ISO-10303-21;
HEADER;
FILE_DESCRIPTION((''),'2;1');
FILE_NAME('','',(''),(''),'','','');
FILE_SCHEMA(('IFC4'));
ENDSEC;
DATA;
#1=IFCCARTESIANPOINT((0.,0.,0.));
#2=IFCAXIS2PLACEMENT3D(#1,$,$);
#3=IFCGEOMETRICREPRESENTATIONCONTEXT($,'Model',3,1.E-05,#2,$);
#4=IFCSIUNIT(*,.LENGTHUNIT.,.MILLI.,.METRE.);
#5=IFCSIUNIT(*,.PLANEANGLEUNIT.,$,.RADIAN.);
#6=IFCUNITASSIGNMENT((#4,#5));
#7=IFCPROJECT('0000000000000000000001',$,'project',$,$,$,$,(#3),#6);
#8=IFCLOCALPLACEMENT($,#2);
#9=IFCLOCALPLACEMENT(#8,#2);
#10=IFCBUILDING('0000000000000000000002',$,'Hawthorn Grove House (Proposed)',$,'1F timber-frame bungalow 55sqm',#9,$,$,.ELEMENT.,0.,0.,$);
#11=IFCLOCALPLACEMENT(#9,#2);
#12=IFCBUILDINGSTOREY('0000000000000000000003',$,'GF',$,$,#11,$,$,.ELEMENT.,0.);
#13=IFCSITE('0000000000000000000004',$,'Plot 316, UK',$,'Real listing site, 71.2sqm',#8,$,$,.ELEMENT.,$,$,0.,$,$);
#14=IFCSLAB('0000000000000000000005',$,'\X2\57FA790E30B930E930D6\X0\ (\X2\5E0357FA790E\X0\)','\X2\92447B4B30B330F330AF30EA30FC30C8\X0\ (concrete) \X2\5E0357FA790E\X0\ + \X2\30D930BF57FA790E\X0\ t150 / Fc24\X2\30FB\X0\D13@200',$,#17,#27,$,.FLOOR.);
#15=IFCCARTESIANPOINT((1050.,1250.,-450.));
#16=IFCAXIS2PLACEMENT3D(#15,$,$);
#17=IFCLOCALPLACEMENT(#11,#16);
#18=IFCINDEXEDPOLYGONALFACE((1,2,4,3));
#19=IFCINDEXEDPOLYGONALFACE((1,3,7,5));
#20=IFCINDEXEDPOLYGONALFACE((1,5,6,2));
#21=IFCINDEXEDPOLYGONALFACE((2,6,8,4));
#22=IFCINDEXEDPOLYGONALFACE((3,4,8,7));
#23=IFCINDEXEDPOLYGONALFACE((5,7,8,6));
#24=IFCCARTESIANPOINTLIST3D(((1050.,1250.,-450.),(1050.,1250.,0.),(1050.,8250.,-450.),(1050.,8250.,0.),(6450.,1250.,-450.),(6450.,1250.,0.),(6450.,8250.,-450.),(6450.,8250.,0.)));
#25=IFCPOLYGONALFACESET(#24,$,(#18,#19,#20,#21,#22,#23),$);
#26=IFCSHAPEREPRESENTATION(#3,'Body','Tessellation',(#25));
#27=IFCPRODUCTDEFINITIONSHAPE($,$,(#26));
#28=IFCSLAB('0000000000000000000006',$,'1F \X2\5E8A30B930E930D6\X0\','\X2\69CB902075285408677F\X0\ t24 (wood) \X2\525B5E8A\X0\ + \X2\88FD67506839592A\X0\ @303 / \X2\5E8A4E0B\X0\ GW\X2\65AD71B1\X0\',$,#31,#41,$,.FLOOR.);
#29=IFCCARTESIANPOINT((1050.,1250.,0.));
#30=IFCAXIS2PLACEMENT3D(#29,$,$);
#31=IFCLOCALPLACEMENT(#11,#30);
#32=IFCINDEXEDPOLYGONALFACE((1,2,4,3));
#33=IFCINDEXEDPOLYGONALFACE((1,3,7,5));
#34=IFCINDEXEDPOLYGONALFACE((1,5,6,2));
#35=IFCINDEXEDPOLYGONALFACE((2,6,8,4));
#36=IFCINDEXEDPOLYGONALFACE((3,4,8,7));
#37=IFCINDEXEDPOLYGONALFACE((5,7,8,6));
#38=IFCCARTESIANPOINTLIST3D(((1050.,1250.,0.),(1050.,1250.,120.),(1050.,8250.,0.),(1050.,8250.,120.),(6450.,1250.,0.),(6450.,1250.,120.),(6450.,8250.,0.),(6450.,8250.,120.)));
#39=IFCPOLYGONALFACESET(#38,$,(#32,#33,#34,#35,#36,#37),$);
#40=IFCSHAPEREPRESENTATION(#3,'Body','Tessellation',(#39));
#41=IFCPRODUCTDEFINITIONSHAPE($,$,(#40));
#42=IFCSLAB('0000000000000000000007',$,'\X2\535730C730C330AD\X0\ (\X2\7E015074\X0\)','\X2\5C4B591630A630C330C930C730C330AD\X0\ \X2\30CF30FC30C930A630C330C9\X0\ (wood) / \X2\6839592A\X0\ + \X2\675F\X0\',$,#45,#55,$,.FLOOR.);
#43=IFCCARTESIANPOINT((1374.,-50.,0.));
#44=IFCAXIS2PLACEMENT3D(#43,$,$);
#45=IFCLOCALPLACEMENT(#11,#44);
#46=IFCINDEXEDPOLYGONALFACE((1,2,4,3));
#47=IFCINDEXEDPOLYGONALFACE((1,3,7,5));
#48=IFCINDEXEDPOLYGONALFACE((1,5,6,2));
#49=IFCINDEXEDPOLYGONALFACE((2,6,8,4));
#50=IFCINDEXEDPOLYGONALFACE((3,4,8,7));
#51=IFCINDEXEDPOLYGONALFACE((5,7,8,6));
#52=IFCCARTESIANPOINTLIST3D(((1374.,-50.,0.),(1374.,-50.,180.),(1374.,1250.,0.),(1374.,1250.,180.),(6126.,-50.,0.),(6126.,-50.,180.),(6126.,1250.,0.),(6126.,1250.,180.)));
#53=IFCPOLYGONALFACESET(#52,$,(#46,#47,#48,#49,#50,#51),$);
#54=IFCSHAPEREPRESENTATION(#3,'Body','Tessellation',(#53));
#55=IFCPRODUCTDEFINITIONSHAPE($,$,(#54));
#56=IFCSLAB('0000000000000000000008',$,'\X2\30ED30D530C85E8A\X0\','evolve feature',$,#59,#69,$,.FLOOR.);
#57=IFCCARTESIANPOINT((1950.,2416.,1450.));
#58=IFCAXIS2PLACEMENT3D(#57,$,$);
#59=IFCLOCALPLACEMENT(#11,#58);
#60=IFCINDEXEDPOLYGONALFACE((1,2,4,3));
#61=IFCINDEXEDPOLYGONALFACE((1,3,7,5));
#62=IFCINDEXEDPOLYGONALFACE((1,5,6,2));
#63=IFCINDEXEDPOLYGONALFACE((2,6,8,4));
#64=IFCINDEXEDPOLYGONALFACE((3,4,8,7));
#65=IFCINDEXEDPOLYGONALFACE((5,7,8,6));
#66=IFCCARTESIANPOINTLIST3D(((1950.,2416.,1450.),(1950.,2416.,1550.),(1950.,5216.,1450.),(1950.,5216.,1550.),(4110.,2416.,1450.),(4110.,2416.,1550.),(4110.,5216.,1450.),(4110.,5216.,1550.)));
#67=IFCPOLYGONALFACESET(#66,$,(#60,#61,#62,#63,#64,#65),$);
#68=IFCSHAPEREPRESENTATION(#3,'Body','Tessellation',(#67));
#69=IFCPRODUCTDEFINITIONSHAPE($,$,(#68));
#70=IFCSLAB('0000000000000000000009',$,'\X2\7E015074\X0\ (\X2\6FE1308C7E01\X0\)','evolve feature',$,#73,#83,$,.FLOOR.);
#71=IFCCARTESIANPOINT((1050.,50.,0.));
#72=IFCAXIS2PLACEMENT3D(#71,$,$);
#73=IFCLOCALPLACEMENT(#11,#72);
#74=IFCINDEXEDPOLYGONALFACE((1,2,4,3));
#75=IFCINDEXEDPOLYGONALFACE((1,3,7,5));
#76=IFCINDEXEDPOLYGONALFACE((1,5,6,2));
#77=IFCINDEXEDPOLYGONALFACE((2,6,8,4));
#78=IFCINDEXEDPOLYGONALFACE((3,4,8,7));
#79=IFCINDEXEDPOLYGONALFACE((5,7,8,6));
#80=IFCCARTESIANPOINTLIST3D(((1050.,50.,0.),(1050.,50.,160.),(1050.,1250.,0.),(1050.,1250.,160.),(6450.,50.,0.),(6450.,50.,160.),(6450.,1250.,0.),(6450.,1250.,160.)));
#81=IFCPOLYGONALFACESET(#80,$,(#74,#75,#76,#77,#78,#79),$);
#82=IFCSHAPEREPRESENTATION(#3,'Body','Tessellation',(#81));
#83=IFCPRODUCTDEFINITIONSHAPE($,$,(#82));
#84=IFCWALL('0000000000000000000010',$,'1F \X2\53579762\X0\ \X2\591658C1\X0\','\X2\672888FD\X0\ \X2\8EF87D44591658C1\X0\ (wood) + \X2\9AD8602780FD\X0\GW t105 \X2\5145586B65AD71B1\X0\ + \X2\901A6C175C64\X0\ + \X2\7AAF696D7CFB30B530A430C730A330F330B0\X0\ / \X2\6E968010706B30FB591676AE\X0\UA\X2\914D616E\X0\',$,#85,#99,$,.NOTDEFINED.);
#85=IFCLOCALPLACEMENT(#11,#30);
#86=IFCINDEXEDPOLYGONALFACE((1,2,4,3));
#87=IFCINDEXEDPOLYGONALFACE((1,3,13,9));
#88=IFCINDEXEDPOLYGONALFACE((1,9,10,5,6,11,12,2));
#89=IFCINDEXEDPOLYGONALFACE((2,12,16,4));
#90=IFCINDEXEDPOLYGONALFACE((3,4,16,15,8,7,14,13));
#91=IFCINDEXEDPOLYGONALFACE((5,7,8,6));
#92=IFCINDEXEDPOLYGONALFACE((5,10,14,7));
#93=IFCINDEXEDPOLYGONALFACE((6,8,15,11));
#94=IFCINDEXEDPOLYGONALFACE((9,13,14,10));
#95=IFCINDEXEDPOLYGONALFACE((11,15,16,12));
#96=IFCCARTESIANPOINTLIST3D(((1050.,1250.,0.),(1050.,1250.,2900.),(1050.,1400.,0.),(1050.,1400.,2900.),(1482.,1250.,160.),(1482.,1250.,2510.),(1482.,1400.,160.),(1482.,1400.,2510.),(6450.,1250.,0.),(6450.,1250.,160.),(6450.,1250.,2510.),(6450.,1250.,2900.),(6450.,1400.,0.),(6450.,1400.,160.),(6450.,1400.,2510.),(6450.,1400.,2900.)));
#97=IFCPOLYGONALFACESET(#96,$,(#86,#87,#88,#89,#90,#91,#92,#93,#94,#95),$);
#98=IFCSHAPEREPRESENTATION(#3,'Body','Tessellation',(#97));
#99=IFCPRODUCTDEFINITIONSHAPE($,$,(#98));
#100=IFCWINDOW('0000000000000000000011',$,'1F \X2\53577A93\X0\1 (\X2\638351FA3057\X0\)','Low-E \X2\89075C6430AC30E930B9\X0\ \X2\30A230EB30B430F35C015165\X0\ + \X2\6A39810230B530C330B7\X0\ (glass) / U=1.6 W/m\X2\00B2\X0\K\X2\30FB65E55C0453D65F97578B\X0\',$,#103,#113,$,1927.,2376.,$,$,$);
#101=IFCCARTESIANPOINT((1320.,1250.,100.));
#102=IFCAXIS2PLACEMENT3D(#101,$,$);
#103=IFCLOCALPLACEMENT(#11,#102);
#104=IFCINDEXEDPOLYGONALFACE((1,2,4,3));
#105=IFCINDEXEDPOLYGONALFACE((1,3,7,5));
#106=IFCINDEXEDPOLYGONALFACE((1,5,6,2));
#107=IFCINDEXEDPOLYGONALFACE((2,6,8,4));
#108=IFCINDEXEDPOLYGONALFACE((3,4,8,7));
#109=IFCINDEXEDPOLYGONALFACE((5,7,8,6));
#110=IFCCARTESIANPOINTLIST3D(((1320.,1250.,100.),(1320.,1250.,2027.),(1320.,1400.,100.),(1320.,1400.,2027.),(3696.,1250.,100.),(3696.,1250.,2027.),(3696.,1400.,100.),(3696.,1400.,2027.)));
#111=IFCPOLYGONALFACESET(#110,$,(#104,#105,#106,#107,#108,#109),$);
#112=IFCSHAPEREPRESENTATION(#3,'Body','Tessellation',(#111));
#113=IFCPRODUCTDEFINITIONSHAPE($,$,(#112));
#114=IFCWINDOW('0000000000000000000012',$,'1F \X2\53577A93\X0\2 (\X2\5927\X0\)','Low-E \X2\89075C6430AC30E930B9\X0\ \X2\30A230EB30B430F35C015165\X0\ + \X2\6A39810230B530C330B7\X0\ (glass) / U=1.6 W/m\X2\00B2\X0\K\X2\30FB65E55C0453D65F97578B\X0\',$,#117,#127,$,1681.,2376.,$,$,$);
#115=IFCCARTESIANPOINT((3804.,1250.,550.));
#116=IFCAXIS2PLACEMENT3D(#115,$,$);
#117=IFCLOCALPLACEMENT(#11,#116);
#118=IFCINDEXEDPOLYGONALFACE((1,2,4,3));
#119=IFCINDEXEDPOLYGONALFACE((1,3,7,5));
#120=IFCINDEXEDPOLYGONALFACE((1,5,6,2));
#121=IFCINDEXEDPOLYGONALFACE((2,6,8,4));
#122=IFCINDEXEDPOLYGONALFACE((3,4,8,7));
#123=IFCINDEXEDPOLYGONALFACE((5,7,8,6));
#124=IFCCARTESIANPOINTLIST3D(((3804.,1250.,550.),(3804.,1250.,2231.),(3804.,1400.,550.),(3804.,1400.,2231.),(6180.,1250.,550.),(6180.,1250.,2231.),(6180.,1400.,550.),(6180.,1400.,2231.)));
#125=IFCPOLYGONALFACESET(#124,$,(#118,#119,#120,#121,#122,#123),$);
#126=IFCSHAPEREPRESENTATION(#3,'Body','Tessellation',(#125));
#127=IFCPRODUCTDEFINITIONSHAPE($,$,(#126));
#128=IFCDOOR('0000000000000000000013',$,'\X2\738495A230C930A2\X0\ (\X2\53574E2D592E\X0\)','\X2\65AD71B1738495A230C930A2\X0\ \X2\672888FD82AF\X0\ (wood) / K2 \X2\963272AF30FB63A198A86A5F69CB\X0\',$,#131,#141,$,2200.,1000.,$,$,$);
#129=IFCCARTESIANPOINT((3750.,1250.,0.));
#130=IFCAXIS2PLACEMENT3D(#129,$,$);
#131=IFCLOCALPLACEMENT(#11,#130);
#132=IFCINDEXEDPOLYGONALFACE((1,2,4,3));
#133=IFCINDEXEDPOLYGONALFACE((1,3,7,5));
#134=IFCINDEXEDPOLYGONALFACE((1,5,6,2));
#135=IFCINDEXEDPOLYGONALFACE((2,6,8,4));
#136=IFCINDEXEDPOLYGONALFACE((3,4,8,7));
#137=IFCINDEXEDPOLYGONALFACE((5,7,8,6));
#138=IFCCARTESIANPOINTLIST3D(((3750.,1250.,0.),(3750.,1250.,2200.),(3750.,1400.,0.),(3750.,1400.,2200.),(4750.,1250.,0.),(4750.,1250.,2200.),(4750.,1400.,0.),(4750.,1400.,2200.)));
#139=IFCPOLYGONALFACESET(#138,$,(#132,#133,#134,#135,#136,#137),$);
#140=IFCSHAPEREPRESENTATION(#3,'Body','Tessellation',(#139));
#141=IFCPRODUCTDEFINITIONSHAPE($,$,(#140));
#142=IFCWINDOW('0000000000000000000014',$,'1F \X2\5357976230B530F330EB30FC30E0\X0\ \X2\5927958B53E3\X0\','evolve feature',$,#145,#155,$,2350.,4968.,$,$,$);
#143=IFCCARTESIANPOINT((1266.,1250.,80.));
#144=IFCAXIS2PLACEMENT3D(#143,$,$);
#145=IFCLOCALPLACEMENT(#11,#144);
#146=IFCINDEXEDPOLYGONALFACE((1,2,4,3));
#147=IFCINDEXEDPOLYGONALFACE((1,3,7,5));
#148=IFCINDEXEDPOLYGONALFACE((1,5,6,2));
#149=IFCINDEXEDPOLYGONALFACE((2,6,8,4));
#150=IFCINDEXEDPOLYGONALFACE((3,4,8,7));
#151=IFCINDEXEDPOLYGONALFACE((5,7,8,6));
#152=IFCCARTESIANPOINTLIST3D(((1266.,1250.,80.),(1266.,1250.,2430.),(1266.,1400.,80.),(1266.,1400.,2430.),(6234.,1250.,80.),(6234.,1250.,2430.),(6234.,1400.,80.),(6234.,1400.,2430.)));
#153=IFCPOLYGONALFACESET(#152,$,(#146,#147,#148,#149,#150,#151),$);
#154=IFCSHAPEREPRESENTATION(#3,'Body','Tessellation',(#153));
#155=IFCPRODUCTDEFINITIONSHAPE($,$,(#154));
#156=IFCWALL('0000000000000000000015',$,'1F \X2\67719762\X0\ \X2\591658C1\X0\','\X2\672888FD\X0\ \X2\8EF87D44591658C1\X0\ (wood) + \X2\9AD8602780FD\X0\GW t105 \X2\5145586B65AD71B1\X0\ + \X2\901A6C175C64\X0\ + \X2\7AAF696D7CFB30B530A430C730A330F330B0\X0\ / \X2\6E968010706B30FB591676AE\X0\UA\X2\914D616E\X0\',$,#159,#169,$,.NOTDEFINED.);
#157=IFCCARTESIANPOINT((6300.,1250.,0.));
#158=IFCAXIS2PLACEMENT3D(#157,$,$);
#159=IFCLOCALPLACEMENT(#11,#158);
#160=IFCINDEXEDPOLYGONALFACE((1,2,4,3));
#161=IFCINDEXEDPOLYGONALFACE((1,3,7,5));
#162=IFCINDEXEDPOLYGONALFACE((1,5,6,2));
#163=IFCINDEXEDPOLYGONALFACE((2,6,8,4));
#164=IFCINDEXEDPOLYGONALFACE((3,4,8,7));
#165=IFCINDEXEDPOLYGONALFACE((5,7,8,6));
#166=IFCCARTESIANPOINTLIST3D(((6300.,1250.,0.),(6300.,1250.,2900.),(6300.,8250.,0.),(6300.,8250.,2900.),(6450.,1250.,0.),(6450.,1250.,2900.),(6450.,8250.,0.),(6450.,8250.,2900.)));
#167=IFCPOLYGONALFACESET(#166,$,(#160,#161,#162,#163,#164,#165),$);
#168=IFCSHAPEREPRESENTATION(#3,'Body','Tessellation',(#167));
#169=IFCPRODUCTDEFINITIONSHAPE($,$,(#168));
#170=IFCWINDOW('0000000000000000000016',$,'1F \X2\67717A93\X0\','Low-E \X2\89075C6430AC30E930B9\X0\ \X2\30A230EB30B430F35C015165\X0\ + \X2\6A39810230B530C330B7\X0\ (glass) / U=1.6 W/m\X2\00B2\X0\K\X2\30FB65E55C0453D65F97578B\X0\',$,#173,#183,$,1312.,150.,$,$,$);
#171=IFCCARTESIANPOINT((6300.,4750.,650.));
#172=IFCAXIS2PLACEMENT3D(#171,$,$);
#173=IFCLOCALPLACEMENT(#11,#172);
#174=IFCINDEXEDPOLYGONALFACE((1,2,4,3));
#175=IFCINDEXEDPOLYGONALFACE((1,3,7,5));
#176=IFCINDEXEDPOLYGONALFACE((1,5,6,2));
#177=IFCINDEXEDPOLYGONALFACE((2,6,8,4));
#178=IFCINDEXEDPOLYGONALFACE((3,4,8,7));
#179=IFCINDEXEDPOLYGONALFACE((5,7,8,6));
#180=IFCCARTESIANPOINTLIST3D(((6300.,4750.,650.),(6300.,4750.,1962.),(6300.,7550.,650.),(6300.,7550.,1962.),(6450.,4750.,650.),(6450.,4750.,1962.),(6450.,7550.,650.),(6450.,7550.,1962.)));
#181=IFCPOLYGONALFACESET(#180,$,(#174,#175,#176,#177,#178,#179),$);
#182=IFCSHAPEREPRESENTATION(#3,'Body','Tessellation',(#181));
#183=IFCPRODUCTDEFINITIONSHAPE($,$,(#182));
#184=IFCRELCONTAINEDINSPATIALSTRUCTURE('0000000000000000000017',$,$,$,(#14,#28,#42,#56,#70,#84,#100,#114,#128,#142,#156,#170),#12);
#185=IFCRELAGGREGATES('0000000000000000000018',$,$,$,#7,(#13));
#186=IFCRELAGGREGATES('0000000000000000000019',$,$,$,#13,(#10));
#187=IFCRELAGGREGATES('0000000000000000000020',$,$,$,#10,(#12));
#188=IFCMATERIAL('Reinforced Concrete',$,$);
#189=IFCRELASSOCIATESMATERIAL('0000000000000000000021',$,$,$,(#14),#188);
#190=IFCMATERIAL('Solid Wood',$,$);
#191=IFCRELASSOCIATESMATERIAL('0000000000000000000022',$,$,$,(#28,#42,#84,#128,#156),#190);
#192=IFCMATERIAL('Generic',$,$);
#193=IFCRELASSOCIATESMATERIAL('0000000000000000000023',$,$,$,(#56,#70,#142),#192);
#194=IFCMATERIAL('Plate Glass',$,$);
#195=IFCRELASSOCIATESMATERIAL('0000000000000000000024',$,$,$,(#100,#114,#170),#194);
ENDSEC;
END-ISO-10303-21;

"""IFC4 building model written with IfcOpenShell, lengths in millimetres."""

from ifc_helpers import new_model, si_unit, frame, frame_2d, origin, place, context, project, spatial, rectangle, extrude, material, element, fill, save


model = new_model("IFC4")

# Units and contexts
model_context = context("Model", 3, precision=1e-05, world=origin())
ifc_project = project(units=[si_unit("LENGTHUNIT", "METRE", prefix="MILLI"), si_unit("PLANEANGLEUNIT", "RADIAN")], contexts=[model_context])

# Site, building, storey
site_placement = place(None, origin())
site = spatial("IfcSite", under=ifc_project, at=site_placement, Name="Plot 316, UK", ObjectType="Real listing site, 71.2sqm", CompositionType="ELEMENT", RefElevation=0.0)
building_placement = place(site_placement, origin())
building = spatial("IfcBuilding", under=site, at=building_placement, Name="Hawthorn Grove House (Proposed)", ObjectType="1F timber-frame bungalow 55sqm", CompositionType="ELEMENT", ElevationOfRefHeight=0.0, ElevationOfTerrain=0.0)
storey_placement = place(building_placement, origin())
storey = spatial("IfcBuildingStorey", under=building, at=storey_placement, Name="GF", CompositionType="ELEMENT", Elevation=0.0)

# Slabs
ifc_material_1 = material(Name="Reinforced Concrete")
slab_1_placement = place(storey_placement, frame((1050.0, 1250.0, -450.0)))
element("IfcSlab", 1, at=slab_1_placement, inside=storey, material=ifc_material_1, Name="基礎スラブ (布基礎)", Description="鉄筋コンクリート (concrete) 布基礎 + ベタ基礎 t150 / Fc24・D13@200", PredefinedType="FLOOR", context=model_context, shape_type="SweptSolid", body=[
    extrude(rectangle(XDim=5400.0, YDim=7000.0, at=frame_2d((2700.0, 3500.0))), frame((1050.0, 1250.0, -450.0)), (0.0, 0.0, 1.0), 450.0),
])
ifc_material_2 = material(Name="Solid Wood")
slab_2_placement = place(storey_placement, frame((1050.0, 1250.0, 0.0)))
element("IfcSlab", 2, at=slab_2_placement, inside=storey, material=ifc_material_2, Name="1F 床スラブ", Description="構造用合板 t24 (wood) 剛床 + 製材根太 @303 / 床下 GW断熱", PredefinedType="FLOOR", context=model_context, shape_type="SweptSolid", body=[
    extrude(rectangle(XDim=5400.0, YDim=7000.0, at=frame_2d((2700.0, 3500.0))), frame((1050.0, 1250.0, 0.0)), (0.0, 0.0, 1.0), 120.0),
])
slab_3_placement = place(storey_placement, frame((1374.0, -50.0, 0.0)))
element("IfcSlab", 3, at=slab_3_placement, inside=storey, material=ifc_material_2, Name="南デッキ (縁側)", Description="屋外ウッドデッキ ハードウッド (wood) / 根太 + 束", PredefinedType="FLOOR", context=model_context, shape_type="SweptSolid", body=[
    extrude(rectangle(XDim=4752.0, YDim=1300.0, at=frame_2d((2376.0, 650.0))), frame((1374.0, -50.0, 0.0)), (0.0, 0.0, 1.0), 180.0),
])
ifc_material_3 = material(Name="Generic")
slab_4_placement = place(storey_placement, frame((1950.0, 2416.0, 1450.0)))
element("IfcSlab", 4, at=slab_4_placement, inside=storey, material=ifc_material_3, Name="ロフト床", Description="evolve feature", PredefinedType="FLOOR", context=model_context, shape_type="SweptSolid", body=[
    extrude(rectangle(XDim=2160.0, YDim=2800.0, at=frame_2d((1080.0, 1400.0))), frame((1950.0, 2416.0, 1450.0)), (0.0, 0.0, 1.0), 100.0),
])
slab_5_placement = place(storey_placement, frame((1050.0, 50.0, 0.0)))
element("IfcSlab", 5, at=slab_5_placement, inside=storey, material=ifc_material_3, Name="縁側 (濡れ縁)", Description="evolve feature", PredefinedType="FLOOR", context=model_context, shape_type="SweptSolid", body=[
    extrude(rectangle(XDim=5400.0, YDim=1200.0, at=frame_2d((2700.0, 600.0))), frame((1050.0, 50.0, 0.0)), (0.0, 0.0, 1.0), 160.0),
])

# Wall, openings, windows, door
wall_1_placement = place(storey_placement, frame((1050.0, 1250.0, 0.0)))
wall_1 = element("IfcWall", 6, at=wall_1_placement, inside=storey, material=ifc_material_2, Name="1F 南面 外壁", Description="木製 軸組外壁 (wood) + 高性能GW t105 充填断熱 + 通気層 + 窯業系サイディング / 準耐火・外皮UA配慮", PredefinedType="NOTDEFINED", context=model_context, shape_type="SweptSolid", body=[
    extrude(rectangle(XDim=5400.0, YDim=150.0, at=frame_2d((2700.0, 75.0))), frame((1050.0, 1250.0, 0.0)), (0.0, 0.0, 1.0), 2900.0),
])
opening_1_placement = place(storey_placement, frame((1320.0, 1250.0, 100.0)))
opening_1 = element("IfcOpeningElement", 7, at=opening_1_placement, cuts=wall_1, PredefinedType="NOTDEFINED", context=model_context, shape_type="SweptSolid", body=[
    extrude(rectangle(XDim=2376.0, YDim=150.0, at=frame_2d((1188.0, 75.0))), frame((1320.0, 1250.0, 100.0)), (0.0, 0.0, 1.0), 1927.0),
])
opening_2_placement = place(storey_placement, frame((3804.0, 1250.0, 550.0)))
opening_2 = element("IfcOpeningElement", 8, at=opening_2_placement, cuts=wall_1, PredefinedType="NOTDEFINED", context=model_context, shape_type="SweptSolid", body=[
    extrude(rectangle(XDim=2376.0, YDim=150.0, at=frame_2d((1188.0, 75.0))), frame((3804.0, 1250.0, 550.0)), (0.0, 0.0, 1.0), 1681.0),
])
opening_3_placement = place(storey_placement, frame((3750.0, 1250.0, 0.0)))
opening_3 = element("IfcOpeningElement", 9, at=opening_3_placement, cuts=wall_1, PredefinedType="NOTDEFINED", context=model_context, shape_type="SweptSolid", body=[
    extrude(rectangle(XDim=1000.0, YDim=150.0, at=frame_2d((500.0, 75.0))), frame((3750.0, 1250.0, 0.0)), (0.0, 0.0, 1.0), 2200.0),
])
opening_4_placement = place(storey_placement, frame((1266.0, 1250.0, 80.0)))
opening_4 = element("IfcOpeningElement", 10, at=opening_4_placement, cuts=wall_1, PredefinedType="NOTDEFINED", context=model_context, shape_type="SweptSolid", body=[
    extrude(rectangle(XDim=4968.0, YDim=150.0, at=frame_2d((2484.0, 75.0))), frame((1266.0, 1250.0, 80.0)), (0.0, 0.0, 1.0), 2350.0),
])
ifc_material_4 = material(Name="Plate Glass")
window_1_placement = place(storey_placement, frame((1320.0, 1250.0, 100.0)))
window_1 = element("IfcWindow", 11, at=window_1_placement, inside=storey, material=ifc_material_4, Name="1F 南窓1 (掃出し)", Description="Low-E 複層ガラス アルゴン封入 + 樹脂サッシ (glass) / U=1.6 W/m²K・日射取得型", OverallHeight=1927.0, OverallWidth=2376.0, context=model_context, shape_type="SweptSolid", body=[
    extrude(rectangle(XDim=2376.0, YDim=150.0, at=frame_2d((1188.0, 75.0))), frame((1320.0, 1250.0, 100.0)), (0.0, 0.0, 1.0), 1927.0),
])
fill(opening_1, window_1)
window_2_placement = place(storey_placement, frame((3804.0, 1250.0, 550.0)))
window_2 = element("IfcWindow", 12, at=window_2_placement, inside=storey, material=ifc_material_4, Name="1F 南窓2 (大)", Description="Low-E 複層ガラス アルゴン封入 + 樹脂サッシ (glass) / U=1.6 W/m²K・日射取得型", OverallHeight=1681.0, OverallWidth=2376.0, context=model_context, shape_type="SweptSolid", body=[
    extrude(rectangle(XDim=2376.0, YDim=150.0, at=frame_2d((1188.0, 75.0))), frame((3804.0, 1250.0, 550.0)), (0.0, 0.0, 1.0), 1681.0),
])
fill(opening_2, window_2)
door_placement = place(storey_placement, frame((3750.0, 1250.0, 0.0)))
door = element("IfcDoor", 13, at=door_placement, inside=storey, material=ifc_material_2, Name="玄関ドア (南中央)", Description="断熱玄関ドア 木製芯 (wood) / K2 防犯・採風機構", OverallHeight=2200.0, OverallWidth=1000.0, context=model_context, shape_type="SweptSolid", body=[
    extrude(rectangle(XDim=1000.0, YDim=150.0, at=frame_2d((500.0, 75.0))), frame((3750.0, 1250.0, 0.0)), (0.0, 0.0, 1.0), 2200.0),
])
fill(opening_3, door)
window_3_placement = place(storey_placement, frame((1266.0, 1250.0, 80.0)))
window_3 = element("IfcWindow", 14, at=window_3_placement, inside=storey, material=ifc_material_3, Name="1F 南面サンルーム 大開口", Description="evolve feature", OverallHeight=2350.0, OverallWidth=4968.0, context=model_context, shape_type="SweptSolid", body=[
    extrude(rectangle(XDim=4968.0, YDim=150.0, at=frame_2d((2484.0, 75.0))), frame((1266.0, 1250.0, 80.0)), (0.0, 0.0, 1.0), 2350.0),
])
fill(opening_4, window_3)

# Wall, opening, window
wall_2_placement = place(storey_placement, frame((6300.0, 1250.0, 0.0)))
wall_2 = element("IfcWall", 15, at=wall_2_placement, inside=storey, material=ifc_material_2, Name="1F 東面 外壁", Description="木製 軸組外壁 (wood) + 高性能GW t105 充填断熱 + 通気層 + 窯業系サイディング / 準耐火・外皮UA配慮", PredefinedType="NOTDEFINED", context=model_context, shape_type="SweptSolid", body=[
    extrude(rectangle(XDim=150.0, YDim=7000.0, at=frame_2d((75.0, 3500.0))), frame((6300.0, 1250.0, 0.0)), (0.0, 0.0, 1.0), 2900.0),
])
opening_5_placement = place(storey_placement, frame((6300.0, 4750.0, 650.0)))
opening_5 = element("IfcOpeningElement", 16, at=opening_5_placement, cuts=wall_2, PredefinedType="NOTDEFINED", context=model_context, shape_type="SweptSolid", body=[
    extrude(rectangle(XDim=150.0, YDim=2800.0, at=frame_2d((75.0, 1400.0))), frame((6300.0, 4750.0, 650.0)), (0.0, 0.0, 1.0), 1312.0),
])
window_4_placement = place(storey_placement, frame((6300.0, 4750.0, 650.0)))
window_4 = element("IfcWindow", 17, at=window_4_placement, inside=storey, material=ifc_material_4, Name="1F 東窓", Description="Low-E 複層ガラス アルゴン封入 + 樹脂サッシ (glass) / U=1.6 W/m²K・日射取得型", OverallHeight=1312.0, OverallWidth=150.0, context=model_context, shape_type="SweptSolid", body=[
    extrude(rectangle(XDim=150.0, YDim=2800.0, at=frame_2d((75.0, 1400.0))), frame((6300.0, 4750.0, 650.0)), (0.0, 0.0, 1.0), 1312.0),
])
fill(opening_5, window_4)

save(model, "model.ifc")
